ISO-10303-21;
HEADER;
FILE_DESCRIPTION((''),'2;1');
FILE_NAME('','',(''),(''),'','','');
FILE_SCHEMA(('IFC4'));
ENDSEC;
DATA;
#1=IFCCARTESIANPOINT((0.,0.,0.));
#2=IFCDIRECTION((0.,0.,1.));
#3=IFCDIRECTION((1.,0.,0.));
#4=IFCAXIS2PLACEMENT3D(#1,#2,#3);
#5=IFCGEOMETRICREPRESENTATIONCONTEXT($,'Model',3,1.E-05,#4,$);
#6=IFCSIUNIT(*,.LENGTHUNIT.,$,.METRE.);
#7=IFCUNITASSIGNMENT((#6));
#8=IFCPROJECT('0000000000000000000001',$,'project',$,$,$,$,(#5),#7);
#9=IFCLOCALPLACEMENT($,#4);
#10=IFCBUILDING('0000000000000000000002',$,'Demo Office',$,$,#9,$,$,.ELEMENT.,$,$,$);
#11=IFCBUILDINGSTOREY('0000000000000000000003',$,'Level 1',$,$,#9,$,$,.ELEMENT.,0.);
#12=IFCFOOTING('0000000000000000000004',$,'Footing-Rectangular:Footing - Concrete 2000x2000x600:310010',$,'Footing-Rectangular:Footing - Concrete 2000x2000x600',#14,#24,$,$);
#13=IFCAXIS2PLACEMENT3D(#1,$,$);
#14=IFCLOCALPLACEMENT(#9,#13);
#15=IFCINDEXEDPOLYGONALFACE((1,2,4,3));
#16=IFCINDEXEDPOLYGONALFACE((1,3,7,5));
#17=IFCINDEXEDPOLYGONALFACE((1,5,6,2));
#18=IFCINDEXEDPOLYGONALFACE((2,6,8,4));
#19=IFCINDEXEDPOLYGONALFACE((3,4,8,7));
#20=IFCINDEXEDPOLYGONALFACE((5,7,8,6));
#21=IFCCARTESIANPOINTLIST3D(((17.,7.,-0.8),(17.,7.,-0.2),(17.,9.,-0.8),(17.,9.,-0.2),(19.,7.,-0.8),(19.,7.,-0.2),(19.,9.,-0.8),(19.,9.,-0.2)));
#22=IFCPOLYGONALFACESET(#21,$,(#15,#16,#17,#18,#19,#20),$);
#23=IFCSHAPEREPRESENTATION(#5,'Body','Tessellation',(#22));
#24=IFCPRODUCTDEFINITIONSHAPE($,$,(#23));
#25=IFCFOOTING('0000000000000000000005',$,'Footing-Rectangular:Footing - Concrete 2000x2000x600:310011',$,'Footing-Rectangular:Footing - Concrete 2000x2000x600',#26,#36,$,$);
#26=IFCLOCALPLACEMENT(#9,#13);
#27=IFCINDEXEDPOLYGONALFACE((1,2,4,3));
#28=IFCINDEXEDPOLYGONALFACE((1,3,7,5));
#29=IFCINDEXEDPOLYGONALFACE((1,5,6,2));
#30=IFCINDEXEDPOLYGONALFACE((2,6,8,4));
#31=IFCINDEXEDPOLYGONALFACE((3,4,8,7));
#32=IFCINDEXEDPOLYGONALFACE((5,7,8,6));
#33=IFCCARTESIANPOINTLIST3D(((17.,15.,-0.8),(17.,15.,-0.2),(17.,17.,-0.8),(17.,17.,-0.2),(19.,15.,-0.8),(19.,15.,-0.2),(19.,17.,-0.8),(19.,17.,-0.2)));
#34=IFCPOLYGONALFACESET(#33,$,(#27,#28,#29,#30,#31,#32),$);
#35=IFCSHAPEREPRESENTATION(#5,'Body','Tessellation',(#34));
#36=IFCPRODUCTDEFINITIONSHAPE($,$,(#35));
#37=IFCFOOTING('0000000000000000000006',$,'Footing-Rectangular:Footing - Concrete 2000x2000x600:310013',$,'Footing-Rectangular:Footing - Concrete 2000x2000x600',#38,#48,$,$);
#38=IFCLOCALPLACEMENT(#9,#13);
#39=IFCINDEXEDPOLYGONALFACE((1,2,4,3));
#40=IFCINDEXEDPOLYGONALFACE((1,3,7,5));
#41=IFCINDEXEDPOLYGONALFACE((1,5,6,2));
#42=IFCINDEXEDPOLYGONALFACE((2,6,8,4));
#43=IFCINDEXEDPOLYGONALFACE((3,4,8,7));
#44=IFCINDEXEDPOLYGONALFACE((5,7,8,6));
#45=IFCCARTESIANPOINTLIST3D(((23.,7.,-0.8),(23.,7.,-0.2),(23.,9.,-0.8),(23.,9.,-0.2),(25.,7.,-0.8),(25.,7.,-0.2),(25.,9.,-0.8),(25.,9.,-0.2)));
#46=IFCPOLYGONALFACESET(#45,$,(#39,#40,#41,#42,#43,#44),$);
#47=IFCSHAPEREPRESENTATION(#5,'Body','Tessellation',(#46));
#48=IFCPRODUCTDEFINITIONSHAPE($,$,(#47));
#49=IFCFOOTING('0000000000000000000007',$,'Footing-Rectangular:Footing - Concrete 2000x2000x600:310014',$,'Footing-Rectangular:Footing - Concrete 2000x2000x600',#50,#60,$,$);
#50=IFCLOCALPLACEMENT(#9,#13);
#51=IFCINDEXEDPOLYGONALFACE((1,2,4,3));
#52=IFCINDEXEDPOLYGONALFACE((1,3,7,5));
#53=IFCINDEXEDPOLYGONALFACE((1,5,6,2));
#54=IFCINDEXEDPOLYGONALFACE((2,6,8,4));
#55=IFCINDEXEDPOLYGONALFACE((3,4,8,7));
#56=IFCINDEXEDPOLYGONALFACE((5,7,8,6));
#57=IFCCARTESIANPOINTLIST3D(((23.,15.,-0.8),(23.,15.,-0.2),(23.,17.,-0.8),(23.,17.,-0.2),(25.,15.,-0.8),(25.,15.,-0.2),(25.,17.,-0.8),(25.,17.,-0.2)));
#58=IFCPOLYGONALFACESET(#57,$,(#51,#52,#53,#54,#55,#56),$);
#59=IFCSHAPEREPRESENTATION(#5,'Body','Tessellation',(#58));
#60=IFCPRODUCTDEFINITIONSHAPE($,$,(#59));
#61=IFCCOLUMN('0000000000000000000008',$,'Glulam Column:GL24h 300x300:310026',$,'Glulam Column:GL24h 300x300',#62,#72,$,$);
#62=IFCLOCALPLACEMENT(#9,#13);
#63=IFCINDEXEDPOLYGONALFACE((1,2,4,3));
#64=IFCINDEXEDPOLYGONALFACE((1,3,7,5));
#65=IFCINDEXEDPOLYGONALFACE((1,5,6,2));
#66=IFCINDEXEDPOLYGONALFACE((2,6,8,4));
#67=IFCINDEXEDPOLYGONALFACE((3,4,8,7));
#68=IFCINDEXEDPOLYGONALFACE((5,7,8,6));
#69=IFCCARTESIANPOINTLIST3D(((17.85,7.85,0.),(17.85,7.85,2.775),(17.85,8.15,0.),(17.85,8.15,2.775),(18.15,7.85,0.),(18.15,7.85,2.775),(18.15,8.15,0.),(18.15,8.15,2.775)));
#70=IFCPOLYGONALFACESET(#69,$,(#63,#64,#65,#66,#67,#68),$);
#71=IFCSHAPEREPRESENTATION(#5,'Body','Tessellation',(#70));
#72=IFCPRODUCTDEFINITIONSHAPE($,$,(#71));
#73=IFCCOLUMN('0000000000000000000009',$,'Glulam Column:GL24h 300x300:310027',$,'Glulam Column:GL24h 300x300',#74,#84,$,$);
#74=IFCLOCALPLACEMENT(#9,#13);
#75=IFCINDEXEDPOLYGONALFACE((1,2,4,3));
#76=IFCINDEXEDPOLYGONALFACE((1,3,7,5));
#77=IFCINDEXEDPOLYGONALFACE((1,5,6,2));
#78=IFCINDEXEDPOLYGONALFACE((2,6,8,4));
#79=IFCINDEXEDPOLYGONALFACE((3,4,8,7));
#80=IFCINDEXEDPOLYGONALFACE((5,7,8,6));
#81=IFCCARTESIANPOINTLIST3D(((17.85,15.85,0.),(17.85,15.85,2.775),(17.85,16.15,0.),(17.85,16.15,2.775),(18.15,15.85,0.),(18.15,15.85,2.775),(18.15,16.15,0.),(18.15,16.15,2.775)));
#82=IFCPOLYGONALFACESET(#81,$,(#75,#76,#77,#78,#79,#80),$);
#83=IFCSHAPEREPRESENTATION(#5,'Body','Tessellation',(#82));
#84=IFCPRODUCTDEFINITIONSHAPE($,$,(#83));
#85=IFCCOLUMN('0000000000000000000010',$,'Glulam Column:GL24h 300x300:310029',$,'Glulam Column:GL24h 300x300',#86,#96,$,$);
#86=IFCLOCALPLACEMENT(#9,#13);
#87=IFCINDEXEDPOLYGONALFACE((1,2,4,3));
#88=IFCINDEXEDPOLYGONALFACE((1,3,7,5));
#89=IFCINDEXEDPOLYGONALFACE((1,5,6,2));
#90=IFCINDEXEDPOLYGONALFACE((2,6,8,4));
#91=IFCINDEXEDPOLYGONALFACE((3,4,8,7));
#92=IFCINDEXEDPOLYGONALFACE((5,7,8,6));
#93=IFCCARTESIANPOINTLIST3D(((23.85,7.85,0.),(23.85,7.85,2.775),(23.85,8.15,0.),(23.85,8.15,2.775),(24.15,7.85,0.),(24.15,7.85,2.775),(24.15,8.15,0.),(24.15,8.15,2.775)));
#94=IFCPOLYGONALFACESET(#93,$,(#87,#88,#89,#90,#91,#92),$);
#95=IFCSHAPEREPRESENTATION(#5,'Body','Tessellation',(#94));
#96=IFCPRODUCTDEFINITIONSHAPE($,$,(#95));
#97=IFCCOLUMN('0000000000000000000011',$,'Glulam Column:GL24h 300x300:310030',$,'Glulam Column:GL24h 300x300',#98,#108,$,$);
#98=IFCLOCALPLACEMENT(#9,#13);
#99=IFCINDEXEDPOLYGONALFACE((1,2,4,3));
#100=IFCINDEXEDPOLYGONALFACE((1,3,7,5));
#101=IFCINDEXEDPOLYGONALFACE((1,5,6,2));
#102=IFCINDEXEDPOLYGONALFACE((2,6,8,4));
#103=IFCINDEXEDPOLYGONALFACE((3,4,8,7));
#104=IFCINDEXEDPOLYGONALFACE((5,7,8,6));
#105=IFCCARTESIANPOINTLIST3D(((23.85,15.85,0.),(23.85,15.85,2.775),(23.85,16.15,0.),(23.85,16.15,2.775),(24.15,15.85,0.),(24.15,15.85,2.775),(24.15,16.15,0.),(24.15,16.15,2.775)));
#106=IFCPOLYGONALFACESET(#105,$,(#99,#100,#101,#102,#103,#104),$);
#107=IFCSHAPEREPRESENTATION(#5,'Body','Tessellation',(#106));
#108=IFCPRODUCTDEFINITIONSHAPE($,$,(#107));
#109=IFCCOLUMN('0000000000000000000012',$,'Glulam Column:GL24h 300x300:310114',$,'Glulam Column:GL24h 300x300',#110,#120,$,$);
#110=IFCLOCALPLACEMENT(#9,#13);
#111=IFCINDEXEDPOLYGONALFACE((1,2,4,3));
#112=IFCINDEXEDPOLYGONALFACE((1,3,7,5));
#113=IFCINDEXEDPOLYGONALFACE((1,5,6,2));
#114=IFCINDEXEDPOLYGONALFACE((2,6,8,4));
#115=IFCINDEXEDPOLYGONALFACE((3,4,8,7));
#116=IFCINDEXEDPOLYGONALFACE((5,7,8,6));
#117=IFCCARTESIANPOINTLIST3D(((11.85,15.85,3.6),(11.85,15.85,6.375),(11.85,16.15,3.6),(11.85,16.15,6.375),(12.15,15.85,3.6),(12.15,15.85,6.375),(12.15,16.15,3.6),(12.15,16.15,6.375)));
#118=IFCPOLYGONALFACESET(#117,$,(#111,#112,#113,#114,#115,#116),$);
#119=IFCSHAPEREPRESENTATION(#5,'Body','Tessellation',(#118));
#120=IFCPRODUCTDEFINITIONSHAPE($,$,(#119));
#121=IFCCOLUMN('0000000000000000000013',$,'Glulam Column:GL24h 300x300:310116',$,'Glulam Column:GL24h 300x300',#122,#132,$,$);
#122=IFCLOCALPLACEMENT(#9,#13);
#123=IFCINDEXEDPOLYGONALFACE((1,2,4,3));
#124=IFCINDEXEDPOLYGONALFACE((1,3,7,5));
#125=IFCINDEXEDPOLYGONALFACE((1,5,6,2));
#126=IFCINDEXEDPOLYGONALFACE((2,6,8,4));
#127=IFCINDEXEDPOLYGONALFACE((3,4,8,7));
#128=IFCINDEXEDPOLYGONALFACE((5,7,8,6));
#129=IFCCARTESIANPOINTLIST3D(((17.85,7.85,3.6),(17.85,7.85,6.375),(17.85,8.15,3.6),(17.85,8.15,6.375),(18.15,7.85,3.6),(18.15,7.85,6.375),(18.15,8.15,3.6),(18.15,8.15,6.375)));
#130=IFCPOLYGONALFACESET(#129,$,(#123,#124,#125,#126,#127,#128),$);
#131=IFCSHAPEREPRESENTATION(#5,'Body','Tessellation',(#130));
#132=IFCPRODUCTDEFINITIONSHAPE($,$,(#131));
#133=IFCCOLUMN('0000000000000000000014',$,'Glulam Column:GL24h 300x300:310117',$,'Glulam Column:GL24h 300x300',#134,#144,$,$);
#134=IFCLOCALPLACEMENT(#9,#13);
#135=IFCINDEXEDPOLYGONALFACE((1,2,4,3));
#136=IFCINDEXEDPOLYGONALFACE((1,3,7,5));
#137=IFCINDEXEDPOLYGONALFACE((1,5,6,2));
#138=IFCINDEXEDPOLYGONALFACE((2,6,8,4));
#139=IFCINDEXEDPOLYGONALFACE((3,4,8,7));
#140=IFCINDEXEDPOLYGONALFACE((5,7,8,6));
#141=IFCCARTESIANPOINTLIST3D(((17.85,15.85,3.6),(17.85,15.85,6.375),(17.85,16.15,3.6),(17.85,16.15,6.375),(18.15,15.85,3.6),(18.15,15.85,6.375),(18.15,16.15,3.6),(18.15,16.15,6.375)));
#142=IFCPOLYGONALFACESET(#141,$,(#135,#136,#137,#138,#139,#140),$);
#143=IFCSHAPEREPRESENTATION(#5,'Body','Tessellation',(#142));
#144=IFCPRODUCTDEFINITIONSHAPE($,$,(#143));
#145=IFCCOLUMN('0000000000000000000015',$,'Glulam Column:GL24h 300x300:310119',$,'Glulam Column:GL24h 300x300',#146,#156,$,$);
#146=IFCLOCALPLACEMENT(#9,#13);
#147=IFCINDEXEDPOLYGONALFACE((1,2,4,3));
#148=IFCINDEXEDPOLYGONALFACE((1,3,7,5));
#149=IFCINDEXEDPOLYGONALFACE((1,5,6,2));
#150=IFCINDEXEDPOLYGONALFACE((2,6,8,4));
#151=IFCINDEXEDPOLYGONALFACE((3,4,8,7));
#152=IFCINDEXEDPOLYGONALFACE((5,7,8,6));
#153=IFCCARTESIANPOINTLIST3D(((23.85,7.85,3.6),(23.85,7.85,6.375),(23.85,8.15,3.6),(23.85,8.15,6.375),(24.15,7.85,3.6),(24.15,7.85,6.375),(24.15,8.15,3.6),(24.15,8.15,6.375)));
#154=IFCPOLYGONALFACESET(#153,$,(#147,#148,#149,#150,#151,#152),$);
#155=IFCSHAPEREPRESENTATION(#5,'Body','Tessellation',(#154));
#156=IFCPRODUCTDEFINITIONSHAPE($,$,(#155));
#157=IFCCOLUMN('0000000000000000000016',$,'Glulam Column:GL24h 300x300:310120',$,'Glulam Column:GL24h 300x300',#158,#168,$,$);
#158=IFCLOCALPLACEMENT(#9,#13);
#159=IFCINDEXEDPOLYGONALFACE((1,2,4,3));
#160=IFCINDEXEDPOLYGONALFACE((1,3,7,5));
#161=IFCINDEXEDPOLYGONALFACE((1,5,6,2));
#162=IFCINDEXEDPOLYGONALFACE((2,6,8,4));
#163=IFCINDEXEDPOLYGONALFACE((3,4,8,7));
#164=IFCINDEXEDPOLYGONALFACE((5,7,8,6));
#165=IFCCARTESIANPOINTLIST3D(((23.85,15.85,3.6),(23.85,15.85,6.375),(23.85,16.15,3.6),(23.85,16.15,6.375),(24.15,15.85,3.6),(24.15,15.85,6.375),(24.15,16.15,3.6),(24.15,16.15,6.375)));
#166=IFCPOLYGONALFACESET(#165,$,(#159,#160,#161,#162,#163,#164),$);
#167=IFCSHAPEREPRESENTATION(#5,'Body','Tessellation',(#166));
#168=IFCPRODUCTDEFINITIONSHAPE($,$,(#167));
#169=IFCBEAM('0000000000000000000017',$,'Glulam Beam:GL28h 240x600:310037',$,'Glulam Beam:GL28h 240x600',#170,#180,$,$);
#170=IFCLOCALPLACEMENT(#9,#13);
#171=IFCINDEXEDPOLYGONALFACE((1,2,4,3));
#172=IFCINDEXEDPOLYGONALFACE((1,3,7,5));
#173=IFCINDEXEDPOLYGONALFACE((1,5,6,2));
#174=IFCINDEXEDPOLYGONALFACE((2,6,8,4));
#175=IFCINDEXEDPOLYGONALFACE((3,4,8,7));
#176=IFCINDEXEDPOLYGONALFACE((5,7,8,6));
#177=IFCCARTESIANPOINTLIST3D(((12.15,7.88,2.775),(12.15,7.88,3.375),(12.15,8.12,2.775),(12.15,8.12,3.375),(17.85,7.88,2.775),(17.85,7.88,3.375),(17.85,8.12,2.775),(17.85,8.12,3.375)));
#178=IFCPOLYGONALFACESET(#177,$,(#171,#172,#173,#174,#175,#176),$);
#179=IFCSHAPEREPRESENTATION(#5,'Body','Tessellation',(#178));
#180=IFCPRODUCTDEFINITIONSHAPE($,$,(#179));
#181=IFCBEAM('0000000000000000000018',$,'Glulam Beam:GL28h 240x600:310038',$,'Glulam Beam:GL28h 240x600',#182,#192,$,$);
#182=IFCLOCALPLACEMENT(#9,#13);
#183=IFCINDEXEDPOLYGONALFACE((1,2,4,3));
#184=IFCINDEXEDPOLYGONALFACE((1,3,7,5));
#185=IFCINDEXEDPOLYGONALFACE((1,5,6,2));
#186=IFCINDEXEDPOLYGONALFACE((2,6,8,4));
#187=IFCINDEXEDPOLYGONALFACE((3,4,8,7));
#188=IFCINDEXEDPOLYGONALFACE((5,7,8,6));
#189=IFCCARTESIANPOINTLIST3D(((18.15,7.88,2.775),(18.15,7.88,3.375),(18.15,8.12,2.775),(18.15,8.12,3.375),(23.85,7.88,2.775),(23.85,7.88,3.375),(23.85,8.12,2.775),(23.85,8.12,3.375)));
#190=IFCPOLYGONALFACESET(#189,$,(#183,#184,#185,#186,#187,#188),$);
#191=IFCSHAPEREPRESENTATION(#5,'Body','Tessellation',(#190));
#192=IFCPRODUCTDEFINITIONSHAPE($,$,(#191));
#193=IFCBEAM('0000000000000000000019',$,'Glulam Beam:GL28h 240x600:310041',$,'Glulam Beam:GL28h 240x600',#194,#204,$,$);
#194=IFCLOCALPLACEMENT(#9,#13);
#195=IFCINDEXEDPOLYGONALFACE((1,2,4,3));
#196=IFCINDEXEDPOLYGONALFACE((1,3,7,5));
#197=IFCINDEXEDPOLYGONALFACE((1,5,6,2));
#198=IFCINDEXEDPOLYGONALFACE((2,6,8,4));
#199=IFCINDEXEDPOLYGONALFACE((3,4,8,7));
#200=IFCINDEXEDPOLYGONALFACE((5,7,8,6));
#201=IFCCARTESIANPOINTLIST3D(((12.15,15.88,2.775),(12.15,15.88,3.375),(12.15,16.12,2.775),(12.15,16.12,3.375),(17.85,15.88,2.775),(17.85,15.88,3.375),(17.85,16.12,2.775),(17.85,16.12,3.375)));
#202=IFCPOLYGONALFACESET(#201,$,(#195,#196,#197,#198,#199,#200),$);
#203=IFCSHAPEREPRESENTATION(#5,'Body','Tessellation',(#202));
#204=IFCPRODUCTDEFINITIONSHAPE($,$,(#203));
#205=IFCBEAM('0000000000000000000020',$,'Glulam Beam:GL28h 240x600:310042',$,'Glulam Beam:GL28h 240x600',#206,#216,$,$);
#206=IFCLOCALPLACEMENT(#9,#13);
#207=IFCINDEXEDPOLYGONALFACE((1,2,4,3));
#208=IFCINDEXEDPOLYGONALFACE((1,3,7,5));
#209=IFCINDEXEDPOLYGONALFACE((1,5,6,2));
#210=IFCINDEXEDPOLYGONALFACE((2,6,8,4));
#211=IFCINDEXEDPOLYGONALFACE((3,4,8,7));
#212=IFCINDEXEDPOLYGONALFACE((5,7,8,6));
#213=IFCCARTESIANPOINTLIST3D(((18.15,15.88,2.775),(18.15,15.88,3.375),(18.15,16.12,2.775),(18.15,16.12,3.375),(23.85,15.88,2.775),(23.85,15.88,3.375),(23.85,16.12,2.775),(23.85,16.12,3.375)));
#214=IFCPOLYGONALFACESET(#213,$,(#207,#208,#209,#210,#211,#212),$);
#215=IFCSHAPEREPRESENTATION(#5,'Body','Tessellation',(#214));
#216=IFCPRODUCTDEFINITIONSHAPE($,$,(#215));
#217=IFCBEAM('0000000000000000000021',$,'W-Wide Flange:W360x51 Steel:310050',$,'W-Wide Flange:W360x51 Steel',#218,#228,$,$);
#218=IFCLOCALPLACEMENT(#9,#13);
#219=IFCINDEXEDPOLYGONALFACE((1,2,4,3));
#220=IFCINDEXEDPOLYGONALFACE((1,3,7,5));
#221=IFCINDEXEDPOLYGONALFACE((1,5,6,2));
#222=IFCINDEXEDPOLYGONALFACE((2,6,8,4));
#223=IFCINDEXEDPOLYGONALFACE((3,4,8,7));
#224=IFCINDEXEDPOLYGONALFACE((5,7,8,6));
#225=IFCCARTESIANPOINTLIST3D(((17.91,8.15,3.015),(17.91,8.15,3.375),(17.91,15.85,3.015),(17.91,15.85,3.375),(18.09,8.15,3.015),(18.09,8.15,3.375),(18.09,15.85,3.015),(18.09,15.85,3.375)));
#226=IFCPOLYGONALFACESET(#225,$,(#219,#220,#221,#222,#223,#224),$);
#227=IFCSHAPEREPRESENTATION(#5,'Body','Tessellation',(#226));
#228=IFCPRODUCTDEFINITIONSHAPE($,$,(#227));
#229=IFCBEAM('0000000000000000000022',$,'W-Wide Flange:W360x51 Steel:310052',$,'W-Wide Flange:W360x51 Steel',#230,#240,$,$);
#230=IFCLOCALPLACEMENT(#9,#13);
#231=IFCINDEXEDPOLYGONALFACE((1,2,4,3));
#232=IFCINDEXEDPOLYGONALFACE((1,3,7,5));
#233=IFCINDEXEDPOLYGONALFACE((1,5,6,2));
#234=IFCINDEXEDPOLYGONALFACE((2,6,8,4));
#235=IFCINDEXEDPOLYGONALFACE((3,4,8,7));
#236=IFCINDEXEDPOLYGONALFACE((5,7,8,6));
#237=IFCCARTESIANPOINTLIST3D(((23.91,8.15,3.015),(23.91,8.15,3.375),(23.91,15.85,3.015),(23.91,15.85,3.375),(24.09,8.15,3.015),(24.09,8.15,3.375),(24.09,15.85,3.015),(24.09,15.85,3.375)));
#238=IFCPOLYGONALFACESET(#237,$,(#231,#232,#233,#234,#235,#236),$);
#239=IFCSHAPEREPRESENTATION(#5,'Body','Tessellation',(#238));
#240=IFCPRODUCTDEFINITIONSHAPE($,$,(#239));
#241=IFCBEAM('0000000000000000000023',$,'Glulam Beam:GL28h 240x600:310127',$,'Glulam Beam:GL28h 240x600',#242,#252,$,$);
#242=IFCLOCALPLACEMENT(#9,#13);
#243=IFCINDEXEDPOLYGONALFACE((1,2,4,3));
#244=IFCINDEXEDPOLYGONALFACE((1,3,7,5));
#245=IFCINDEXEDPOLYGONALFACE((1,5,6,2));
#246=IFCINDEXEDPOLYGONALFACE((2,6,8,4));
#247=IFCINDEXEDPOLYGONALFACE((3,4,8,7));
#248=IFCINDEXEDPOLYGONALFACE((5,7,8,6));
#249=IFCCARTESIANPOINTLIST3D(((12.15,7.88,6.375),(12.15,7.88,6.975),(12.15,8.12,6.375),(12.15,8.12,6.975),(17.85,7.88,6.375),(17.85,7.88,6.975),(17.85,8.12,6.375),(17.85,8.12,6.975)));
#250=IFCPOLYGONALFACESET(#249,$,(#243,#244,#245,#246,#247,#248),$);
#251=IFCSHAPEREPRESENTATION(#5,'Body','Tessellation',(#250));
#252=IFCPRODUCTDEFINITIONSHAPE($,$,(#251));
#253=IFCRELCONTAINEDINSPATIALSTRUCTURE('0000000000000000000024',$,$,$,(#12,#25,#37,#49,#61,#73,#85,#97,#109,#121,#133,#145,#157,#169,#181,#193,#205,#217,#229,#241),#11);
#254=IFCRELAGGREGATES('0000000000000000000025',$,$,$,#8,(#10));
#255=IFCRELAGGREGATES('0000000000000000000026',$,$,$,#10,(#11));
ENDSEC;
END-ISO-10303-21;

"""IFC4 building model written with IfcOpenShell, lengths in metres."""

from ifc_helpers import new_model, si_unit, frame, origin_with_axes, origin_2d, place, context, project, spatial, rectangle, extrude, element, save


model = new_model("IFC4")

# Units and contexts
model_context = context("Model", 3, precision=1e-05, world=origin_with_axes())
ifc_project = project(units=[si_unit("LENGTHUNIT", "METRE")], contexts=[model_context])

# Building, storey
placement = place(None, origin_with_axes())
building = spatial("IfcBuilding", under=ifc_project, at=placement, Name="Demo Office", CompositionType="ELEMENT")
storey = spatial("IfcBuildingStorey", under=building, at=placement, Name="Level 1", CompositionType="ELEMENT", Elevation=0.0)

# Footings
for number, where, name in (
    (1, (18.0, 8.0, -0.8), "Footing-Rectangular:Footing - Concrete 2000x2000x600:310010"),
    (2, (18.0, 16.0, -0.8), "Footing-Rectangular:Footing - Concrete 2000x2000x600:310011"),
    (3, (24.0, 8.0, -0.8), "Footing-Rectangular:Footing - Concrete 2000x2000x600:310013"),
    (4, (24.0, 16.0, -0.8), "Footing-Rectangular:Footing - Concrete 2000x2000x600:310014"),
):
    element("IfcFooting", number, at=place(placement, frame(where)), inside=storey, Name=name, ObjectType="Footing-Rectangular:Footing - Concrete 2000x2000x600", context=model_context, shape_type="SweptSolid", body=[
        extrude(rectangle(XDim=2.0, YDim=2.0, at=origin_2d()), origin_with_axes(), (0.0, 0.0, 1.0), 0.6),
    ])

# Columns
for number, where, name in (
    (5, (18.0, 8.0, 0.0), "Glulam Column:GL24h 300x300:310026"),
    (6, (18.0, 16.0, 0.0), "Glulam Column:GL24h 300x300:310027"),
    (7, (24.0, 8.0, 0.0), "Glulam Column:GL24h 300x300:310029"),
    (8, (24.0, 16.0, 0.0), "Glulam Column:GL24h 300x300:310030"),
    (9, (12.0, 16.0, 3.6), "Glulam Column:GL24h 300x300:310114"),
    (10, (18.0, 8.0, 3.6), "Glulam Column:GL24h 300x300:310116"),
    (11, (18.0, 16.0, 3.6), "Glulam Column:GL24h 300x300:310117"),
    (12, (24.0, 8.0, 3.6), "Glulam Column:GL24h 300x300:310119"),
    (13, (24.0, 16.0, 3.6), "Glulam Column:GL24h 300x300:310120"),
):
    element("IfcColumn", number, at=place(placement, frame(where)), inside=storey, Name=name, ObjectType="Glulam Column:GL24h 300x300", context=model_context, shape_type="SweptSolid", body=[
        extrude(rectangle(XDim=0.3, YDim=0.3, at=origin_2d()), origin_with_axes(), (0.0, 0.0, 1.0), 2.775),
    ])

# Beams
for number, where, name in (
    (14, (15.0, 8.0, 2.775), "Glulam Beam:GL28h 240x600:310037"),
    (15, (21.0, 8.0, 2.775), "Glulam Beam:GL28h 240x600:310038"),
    (16, (15.0, 16.0, 2.775), "Glulam Beam:GL28h 240x600:310041"),
    (17, (21.0, 16.0, 2.775), "Glulam Beam:GL28h 240x600:310042"),
):
    element("IfcBeam", number, at=place(placement, frame(where)), inside=storey, Name=name, ObjectType="Glulam Beam:GL28h 240x600", context=model_context, shape_type="SweptSolid", body=[
        extrude(rectangle(XDim=5.7, YDim=0.24, at=origin_2d()), origin_with_axes(), (0.0, 0.0, 1.0), 0.6),
    ])
for number, where, name in (
    (18, (18.0, 12.0, 3.015), "W-Wide Flange:W360x51 Steel:310050"),
    (19, (24.0, 12.0, 3.015), "W-Wide Flange:W360x51 Steel:310052"),
):
    element("IfcBeam", number, at=place(placement, frame(where)), inside=storey, Name=name, ObjectType="W-Wide Flange:W360x51 Steel", context=model_context, shape_type="SweptSolid", body=[
        extrude(rectangle(XDim=0.18, YDim=7.7, at=origin_2d()), origin_with_axes(), (0.0, 0.0, 1.0), 0.36),
    ])
for number, where, name in (
    (20, (15.0, 8.0, 6.375), "Glulam Beam:GL28h 240x600:310127"),
):
    element("IfcBeam", number, at=place(placement, frame(where)), inside=storey, Name=name, ObjectType="Glulam Beam:GL28h 240x600", context=model_context, shape_type="SweptSolid", body=[
        extrude(rectangle(XDim=5.7, YDim=0.24, at=origin_2d()), origin_with_axes(), (0.0, 0.0, 1.0), 0.6),
    ])

save(model, "model.ifc")
